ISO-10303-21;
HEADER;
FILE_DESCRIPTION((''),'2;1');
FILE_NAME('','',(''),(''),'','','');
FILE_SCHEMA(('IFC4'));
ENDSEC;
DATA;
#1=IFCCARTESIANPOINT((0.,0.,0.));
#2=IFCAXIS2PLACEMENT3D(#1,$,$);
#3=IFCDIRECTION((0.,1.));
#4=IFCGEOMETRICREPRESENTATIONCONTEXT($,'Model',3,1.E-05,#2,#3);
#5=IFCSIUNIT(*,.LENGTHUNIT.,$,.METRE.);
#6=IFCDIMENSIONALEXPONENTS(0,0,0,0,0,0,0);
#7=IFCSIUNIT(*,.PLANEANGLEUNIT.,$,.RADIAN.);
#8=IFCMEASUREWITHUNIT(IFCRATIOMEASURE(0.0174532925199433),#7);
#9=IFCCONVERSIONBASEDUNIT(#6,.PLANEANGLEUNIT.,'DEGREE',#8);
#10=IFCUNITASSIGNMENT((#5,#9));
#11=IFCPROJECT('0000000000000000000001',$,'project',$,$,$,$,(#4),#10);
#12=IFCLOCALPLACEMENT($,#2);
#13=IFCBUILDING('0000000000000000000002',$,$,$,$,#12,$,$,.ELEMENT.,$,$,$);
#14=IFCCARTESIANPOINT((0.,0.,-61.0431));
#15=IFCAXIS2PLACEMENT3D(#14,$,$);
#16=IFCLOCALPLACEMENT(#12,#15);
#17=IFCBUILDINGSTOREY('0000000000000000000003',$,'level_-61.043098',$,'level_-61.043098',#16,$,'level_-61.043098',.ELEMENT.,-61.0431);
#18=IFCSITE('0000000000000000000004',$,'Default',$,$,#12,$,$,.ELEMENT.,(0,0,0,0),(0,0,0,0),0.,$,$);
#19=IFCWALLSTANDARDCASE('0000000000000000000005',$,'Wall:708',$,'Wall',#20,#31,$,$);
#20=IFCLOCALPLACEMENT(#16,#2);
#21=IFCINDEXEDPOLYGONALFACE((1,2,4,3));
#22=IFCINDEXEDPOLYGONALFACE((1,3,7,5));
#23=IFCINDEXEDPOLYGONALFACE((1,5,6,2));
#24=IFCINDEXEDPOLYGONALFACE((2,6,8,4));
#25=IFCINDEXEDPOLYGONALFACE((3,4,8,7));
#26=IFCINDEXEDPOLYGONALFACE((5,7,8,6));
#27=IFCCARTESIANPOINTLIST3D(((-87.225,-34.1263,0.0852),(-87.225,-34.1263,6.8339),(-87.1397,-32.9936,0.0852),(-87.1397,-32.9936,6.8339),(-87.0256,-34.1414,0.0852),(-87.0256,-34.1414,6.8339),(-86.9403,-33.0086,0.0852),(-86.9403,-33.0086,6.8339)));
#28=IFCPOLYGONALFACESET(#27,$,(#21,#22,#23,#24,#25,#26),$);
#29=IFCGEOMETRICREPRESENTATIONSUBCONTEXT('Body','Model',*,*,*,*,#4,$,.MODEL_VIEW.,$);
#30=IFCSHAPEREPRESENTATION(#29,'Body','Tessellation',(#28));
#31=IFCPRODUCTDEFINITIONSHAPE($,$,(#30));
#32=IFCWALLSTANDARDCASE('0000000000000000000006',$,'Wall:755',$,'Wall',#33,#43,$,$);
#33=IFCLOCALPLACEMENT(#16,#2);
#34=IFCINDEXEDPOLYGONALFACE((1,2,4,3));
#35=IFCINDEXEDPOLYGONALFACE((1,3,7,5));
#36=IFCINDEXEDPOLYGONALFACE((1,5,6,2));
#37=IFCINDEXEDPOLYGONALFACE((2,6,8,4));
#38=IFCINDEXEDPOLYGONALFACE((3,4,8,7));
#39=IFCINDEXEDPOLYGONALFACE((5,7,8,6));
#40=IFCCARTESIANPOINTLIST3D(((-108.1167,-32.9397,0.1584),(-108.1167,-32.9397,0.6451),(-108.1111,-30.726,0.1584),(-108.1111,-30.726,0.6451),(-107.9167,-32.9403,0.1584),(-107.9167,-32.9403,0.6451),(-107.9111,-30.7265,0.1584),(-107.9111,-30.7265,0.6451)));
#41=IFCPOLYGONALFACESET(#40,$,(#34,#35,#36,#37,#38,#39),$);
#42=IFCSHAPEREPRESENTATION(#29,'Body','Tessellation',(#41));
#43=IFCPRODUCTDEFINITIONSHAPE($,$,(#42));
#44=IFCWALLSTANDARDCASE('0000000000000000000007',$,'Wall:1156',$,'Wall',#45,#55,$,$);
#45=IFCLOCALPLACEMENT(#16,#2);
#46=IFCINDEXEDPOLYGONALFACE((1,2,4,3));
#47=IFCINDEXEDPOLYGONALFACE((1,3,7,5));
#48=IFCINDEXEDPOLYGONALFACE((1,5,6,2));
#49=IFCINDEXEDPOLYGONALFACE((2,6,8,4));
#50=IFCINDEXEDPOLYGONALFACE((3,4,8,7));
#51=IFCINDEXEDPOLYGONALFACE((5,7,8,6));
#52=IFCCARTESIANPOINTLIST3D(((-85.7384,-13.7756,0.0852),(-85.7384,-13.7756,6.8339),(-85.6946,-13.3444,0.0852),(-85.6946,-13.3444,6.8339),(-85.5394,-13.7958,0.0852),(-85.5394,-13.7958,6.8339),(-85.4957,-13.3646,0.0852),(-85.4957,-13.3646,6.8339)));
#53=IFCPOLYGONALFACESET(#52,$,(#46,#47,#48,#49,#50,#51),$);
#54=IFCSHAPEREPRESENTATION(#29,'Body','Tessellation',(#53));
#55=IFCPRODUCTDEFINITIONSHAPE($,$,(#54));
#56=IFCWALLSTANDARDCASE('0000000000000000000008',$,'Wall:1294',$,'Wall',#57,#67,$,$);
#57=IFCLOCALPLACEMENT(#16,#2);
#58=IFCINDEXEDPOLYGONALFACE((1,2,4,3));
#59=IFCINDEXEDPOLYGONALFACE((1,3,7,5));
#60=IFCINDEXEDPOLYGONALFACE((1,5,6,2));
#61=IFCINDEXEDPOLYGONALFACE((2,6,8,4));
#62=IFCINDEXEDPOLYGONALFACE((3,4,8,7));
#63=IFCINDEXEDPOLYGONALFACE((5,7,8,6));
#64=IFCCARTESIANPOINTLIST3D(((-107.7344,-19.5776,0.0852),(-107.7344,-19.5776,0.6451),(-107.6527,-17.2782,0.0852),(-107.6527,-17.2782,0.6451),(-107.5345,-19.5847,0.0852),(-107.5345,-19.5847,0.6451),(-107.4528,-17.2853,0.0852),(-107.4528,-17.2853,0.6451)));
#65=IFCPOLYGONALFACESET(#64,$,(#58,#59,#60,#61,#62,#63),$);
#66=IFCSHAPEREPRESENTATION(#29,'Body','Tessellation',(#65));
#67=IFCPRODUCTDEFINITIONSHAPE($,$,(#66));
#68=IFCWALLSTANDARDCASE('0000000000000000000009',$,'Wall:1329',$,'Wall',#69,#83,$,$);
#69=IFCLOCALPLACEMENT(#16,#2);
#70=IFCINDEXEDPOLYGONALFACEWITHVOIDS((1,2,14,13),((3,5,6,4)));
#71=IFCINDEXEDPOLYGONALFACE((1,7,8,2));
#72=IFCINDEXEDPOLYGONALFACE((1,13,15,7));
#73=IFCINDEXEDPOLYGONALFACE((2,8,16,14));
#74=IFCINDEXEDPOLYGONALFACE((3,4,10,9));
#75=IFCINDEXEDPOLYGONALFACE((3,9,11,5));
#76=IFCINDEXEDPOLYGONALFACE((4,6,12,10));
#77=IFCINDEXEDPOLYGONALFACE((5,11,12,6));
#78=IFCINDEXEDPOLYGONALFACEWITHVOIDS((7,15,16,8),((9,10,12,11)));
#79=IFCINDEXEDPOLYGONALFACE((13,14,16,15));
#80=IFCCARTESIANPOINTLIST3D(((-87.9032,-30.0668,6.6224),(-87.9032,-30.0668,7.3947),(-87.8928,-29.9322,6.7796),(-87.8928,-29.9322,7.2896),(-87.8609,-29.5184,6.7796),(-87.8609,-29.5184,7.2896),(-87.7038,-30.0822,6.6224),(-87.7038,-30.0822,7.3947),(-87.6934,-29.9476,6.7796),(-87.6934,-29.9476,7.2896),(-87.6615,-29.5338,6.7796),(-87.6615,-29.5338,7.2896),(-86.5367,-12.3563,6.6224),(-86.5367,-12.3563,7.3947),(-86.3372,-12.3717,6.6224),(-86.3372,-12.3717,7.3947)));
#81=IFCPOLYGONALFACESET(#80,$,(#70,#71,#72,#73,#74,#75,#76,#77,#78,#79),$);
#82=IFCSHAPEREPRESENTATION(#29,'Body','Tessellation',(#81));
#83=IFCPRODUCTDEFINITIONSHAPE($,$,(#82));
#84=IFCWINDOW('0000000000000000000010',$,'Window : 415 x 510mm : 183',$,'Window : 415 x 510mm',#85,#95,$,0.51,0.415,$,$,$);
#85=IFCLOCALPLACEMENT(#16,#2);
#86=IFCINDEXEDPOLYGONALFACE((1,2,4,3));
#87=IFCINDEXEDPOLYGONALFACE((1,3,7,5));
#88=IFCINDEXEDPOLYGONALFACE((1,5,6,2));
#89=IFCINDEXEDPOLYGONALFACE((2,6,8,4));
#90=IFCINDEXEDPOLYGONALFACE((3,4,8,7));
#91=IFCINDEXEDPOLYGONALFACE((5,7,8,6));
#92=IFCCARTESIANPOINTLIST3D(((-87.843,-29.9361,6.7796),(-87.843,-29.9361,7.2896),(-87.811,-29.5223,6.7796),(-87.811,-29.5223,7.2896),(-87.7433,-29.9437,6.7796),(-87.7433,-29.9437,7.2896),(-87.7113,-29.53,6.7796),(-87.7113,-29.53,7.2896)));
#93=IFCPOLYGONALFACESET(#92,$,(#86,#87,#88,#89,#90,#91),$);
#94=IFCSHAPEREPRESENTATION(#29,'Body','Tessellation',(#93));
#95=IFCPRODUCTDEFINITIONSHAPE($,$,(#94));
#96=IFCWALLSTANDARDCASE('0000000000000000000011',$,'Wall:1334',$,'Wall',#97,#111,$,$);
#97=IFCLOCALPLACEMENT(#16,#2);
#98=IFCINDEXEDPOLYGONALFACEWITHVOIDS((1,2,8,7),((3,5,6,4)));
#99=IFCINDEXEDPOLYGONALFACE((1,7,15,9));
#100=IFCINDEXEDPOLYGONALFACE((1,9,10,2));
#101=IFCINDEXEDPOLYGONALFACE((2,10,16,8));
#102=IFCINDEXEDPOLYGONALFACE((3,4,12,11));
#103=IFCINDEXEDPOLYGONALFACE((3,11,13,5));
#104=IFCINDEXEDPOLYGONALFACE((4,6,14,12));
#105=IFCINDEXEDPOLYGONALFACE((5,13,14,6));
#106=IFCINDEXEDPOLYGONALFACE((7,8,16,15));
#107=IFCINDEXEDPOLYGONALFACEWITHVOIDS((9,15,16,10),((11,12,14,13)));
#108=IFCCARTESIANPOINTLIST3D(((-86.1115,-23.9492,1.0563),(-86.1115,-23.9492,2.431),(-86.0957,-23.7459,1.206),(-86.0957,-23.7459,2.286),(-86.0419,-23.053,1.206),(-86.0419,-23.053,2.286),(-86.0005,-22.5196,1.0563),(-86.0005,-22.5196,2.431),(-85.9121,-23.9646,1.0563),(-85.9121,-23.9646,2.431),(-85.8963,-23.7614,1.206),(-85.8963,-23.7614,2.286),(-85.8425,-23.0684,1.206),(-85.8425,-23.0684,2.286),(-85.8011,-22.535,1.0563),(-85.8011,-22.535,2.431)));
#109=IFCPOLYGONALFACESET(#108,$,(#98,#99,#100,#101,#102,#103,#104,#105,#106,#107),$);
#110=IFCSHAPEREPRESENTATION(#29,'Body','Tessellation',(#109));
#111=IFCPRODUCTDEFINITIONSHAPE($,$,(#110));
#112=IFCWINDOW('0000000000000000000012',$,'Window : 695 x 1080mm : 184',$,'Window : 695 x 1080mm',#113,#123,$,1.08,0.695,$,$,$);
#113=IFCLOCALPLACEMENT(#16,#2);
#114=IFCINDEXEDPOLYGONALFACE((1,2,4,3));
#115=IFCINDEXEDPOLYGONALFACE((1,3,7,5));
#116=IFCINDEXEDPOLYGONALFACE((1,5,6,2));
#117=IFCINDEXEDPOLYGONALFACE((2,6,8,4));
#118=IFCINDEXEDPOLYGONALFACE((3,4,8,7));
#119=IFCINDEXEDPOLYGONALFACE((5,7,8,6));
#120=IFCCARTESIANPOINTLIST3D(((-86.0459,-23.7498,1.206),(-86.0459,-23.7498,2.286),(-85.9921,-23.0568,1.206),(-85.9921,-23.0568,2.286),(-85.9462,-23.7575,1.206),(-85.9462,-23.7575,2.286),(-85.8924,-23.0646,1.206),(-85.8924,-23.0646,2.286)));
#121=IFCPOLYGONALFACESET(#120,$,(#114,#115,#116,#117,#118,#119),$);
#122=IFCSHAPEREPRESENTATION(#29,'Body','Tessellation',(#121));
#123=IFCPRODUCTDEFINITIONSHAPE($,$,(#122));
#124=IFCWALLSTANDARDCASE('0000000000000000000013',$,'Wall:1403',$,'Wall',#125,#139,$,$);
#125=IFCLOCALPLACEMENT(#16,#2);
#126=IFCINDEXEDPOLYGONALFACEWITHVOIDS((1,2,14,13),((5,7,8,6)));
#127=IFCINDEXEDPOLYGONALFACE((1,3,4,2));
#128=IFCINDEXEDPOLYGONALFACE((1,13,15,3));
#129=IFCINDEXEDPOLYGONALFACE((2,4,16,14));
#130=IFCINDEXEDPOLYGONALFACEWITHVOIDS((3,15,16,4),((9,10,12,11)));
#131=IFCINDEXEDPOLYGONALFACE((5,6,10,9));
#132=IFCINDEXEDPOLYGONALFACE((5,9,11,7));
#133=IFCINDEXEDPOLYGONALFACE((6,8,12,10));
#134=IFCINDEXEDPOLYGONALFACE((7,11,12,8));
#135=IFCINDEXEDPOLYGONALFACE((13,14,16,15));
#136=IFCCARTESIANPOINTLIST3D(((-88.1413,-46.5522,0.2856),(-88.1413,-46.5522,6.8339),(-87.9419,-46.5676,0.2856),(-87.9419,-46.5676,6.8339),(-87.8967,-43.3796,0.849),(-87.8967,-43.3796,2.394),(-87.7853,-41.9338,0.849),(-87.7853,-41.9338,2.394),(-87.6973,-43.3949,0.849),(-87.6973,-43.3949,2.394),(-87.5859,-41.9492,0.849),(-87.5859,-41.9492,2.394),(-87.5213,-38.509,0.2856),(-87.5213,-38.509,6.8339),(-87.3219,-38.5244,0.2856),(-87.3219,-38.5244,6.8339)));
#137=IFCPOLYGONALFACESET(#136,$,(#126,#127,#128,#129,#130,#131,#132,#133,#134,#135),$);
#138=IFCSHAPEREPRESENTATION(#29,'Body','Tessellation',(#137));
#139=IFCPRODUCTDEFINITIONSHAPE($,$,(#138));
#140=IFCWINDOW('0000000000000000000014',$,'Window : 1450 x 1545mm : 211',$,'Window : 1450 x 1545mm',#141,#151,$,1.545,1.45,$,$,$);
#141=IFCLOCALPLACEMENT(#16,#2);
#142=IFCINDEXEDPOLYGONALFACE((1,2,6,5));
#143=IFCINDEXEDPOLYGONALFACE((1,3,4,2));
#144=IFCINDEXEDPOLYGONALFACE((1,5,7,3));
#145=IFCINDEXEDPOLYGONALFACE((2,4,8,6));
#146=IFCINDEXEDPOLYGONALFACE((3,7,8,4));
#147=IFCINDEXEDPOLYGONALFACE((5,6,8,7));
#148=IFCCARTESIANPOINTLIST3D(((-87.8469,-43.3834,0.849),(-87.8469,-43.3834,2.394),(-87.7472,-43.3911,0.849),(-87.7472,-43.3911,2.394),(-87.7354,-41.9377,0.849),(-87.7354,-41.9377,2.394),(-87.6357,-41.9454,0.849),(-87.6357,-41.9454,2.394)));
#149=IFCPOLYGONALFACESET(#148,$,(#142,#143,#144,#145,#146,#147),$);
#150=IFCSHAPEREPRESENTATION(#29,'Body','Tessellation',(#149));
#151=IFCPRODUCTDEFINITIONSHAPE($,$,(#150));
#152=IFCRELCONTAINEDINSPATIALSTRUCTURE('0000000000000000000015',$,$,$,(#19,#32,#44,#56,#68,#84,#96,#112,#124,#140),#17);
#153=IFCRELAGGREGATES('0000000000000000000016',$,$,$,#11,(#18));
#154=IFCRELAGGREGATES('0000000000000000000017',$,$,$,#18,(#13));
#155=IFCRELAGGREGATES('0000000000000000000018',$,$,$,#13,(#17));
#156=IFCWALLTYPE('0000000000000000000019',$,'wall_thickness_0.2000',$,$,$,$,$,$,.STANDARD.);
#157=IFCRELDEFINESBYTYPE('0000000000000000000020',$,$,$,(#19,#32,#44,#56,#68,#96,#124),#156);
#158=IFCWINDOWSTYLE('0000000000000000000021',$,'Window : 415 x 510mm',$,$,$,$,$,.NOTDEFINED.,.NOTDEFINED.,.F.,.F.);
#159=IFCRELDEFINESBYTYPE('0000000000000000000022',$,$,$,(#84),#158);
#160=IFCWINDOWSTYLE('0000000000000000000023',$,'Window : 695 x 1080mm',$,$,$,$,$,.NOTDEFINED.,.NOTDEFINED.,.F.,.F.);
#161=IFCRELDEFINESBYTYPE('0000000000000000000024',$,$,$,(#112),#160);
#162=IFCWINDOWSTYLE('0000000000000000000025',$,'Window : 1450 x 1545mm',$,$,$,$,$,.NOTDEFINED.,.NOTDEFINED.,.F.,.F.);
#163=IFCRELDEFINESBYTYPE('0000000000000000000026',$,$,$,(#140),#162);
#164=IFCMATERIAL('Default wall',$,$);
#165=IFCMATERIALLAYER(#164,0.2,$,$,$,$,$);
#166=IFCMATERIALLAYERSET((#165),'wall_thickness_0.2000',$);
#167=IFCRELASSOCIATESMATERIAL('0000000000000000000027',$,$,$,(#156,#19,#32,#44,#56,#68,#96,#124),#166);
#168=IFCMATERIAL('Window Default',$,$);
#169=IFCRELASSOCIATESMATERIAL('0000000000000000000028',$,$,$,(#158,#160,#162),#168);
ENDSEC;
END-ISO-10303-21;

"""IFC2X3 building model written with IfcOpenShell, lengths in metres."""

from ifc_helpers import new_model, entity, si_unit, converted_unit, direction, frame, frame_2d, origin, origin_2d_with_axis, place, context, subcontext, project, spatial, polyline, rectangle, outline, extrude, source, transform, mapped, material, layer, layer_set, layer_usage, type_object, type_shapes, element, fill, save


model = new_model("IFC2X3")

# Units and contexts
model_context = context("Model", 3, precision=1e-05, world=origin(), true_north=direction((0.0, 1.0)))
body_context = subcontext(model_context, "Body", "Model", "MODEL_VIEW")
ifc_project = project(units=[si_unit("LENGTHUNIT", "METRE"), converted_unit("PLANEANGLEUNIT", "DEGREE", entity("IfcRatioMeasure", 0.0174532925199433), si_unit("PLANEANGLEUNIT", "RADIAN"), dimensions=[0, 0, 0, 0, 0, 0, 0])], contexts=[model_context])

# Site, building, storey
placement_1 = place(None, origin())
site = spatial("IfcSite", under=ifc_project, at=placement_1, Name="Default", CompositionType="ELEMENT", RefLatitude=(0, 0, 0, 0), RefLongitude=(0, 0, 0, 0), RefElevation=0.0)
building = spatial("IfcBuilding", under=site, at=placement_1, CompositionType="ELEMENT")
storey_placement = place(placement_1, frame((0.0, 0.0, -61.0431)))
storey = spatial("IfcBuildingStorey", under=building, at=storey_placement, Name="level_-61.043098", ObjectType="level_-61.043098", LongName="level_-61.043098", CompositionType="ELEMENT", Elevation=-61.0431)

# Shared definitions
ifc_material_1 = material(Name="Default wall")
ifc_layer = layer(ifc_material_1, 0.2)
ifc_layer_set = layer_set([ifc_layer], Name="wall_thickness_0.2000")
ifc_layer_usage = layer_usage(ifc_layer_set, "AXIS2", "POSITIVE", -0.1)
wall_type = type_object("IfcWallType", Name="wall_thickness_0.2000", PredefinedType="STANDARD", material=ifc_layer_set)

# Shared definitions
ifc_material_2 = material(Name="Window Default")

# Walls
placement_2 = place(placement_1, frame((0.0, 0.0, -60.9579)))
wall_1_placement = place(placement_2, frame((-87.1253, -34.1339, 0.0), z_axis=(0.0, 0.0, 1.0), x_axis=(0.075094, 0.997176, 0.0)))
element("IfcWallStandardCase", 1, at=wall_1_placement, inside=storey, type_object=wall_type, material=ifc_layer_usage, Name="Wall:708", ObjectType="Wall", context=body_context, shape_type="SweptSolid", body=[
    extrude(outline(polyline([(1.136, -0.1), (1.136, 0.1), (0.0, 0.1), (0.0, -0.1), (1.136, -0.1)])), origin(), (0.0, 0.0, 1.0), 6.7487),
])
placement_3 = place(placement_1, frame((0.0, 0.0, -60.8847)))
wall_2_placement = place(placement_3, frame((-108.0167, -32.94, 0.0), z_axis=(0.0, 0.0, 1.0), x_axis=(0.002509, 0.999997, 0.0)))
element("IfcWallStandardCase", 2, at=wall_2_placement, inside=storey, type_object=wall_type, material=ifc_layer_usage, Name="Wall:755", ObjectType="Wall", context=body_context, shape_type="SweptSolid", body=[
    extrude(outline(polyline([(2.2138, -0.1), (2.2138, 0.1), (0.0, 0.1), (0.0, -0.1), (2.2138, -0.1)])), origin(), (0.0, 0.0, 1.0), 0.4867),
])
placement_4 = place(placement_1, frame((0.0, 0.0, -60.9579)))
wall_3_placement = place(placement_4, frame((-85.6389, -13.7857, 0.0), z_axis=(0.0, 0.0, 1.0), x_axis=(0.100936, 0.994893, 0.0)))
element("IfcWallStandardCase", 3, at=wall_3_placement, inside=storey, type_object=wall_type, material=ifc_layer_usage, Name="Wall:1156", ObjectType="Wall", context=body_context, shape_type="SweptSolid", body=[
    extrude(outline(polyline([(0.4334, -0.1), (0.4334, 0.1), (0.0, 0.1), (0.0, -0.1), (0.4334, -0.1)])), origin(), (0.0, 0.0, 1.0), 6.7487),
])
placement_5 = place(placement_1, frame((0.0, 0.0, -60.9579)))
wall_4_placement = place(placement_5, frame((-107.6345, -19.5812, 0.0), z_axis=(0.0, 0.0, 1.0), x_axis=(0.035503, 0.99937, 0.0)))
element("IfcWallStandardCase", 4, at=wall_4_placement, inside=storey, type_object=wall_type, material=ifc_layer_usage, Name="Wall:1294", ObjectType="Wall", context=body_context, shape_type="SweptSolid", body=[
    extrude(outline(polyline([(2.3009, -0.1), (2.3009, 0.1), (0.0, 0.1), (0.0, -0.1), (2.3009, -0.1)])), origin(), (0.0, 0.0, 1.0), 0.5598),
])

# Walls, openings, windows
placement_6 = place(placement_1, frame((0.0, 0.0, -54.4207)))
wall_5_placement = place(placement_6, frame((-87.8035, -30.0745, 0.0), z_axis=(0.0, 0.0, 1.0), x_axis=(0.076932, 0.997036, 0.0)))
wall_5 = element("IfcWallStandardCase", 5, at=wall_5_placement, inside=storey, type_object=wall_type, material=ifc_layer_usage, Name="Wall:1329", ObjectType="Wall", context=body_context, shape_type="SweptSolid", body=[
    extrude(outline(polyline([(17.7631, -0.1), (17.7631, 0.1), (0.0, 0.1), (0.0, -0.1), (17.7631, -0.1)])), origin(), (0.0, 0.0, 1.0), 0.7723),
])
opening_1_placement = place(wall_5_placement, frame((0.135, -0.1, 0.1572)))
opening_1 = element("IfcOpeningElement", 6, at=opening_1_placement, cuts=wall_5, ObjectType="Opening", context=body_context, shape_type="SweptSolid", body=[
    extrude(rectangle(XDim=0.415, YDim=0.51, at=frame_2d((0.255, 0.2075), x_axis=(0.0, 1.0))), frame((0.0, 0.0, 0.0), z_axis=(0.0, 1.0, 0.0), x_axis=(0.0, 0.0, 1.0)), (0.0, 0.0, 1.0), 0.2),
])
window_style_1 = type_object("IfcWindowStyle", Name="Window : 415 x 510mm", ConstructionType="NOTDEFINED", OperationType="NOTDEFINED", ParameterTakesPrecedence=False, Sizeable=False, material=ifc_material_2)
shared_shape_1 = source(origin(), body_context, "Body", "SweptSolid", [
    extrude(rectangle(XDim=0.1, YDim=0.415, at=origin_2d_with_axis()), frame((0.2075, 0.1, 0.0), z_axis=(0.0, 0.0, 1.0), x_axis=(0.0, 1.0, 0.0)), (0.0, 0.0, 1.0), 0.51),
])
type_shapes(window_style_1, [shared_shape_1])
window_1_placement = place(opening_1_placement, origin())
window_1 = element("IfcWindow", 7, at=window_1_placement, inside=storey, type_object=window_style_1, Name="Window : 415 x 510mm : 183", ObjectType="Window : 415 x 510mm", OverallHeight=0.51, OverallWidth=0.415, context=body_context, shape_type="MappedRepresentation", body=[
    mapped(shared_shape_1, transform((0.0, 0.0, 0.0), scale=1.0)),
])
fill(opening_1, window_1)
placement_7 = place(placement_1, frame((0.0, 0.0, -59.9868)))
wall_6_placement = place(placement_7, frame((-85.9008, -22.5273, 0.0), z_axis=(0.0, 0.0, 1.0), x_axis=(-0.077369, -0.997003, 0.0)))
wall_6 = element("IfcWallStandardCase", 8, at=wall_6_placement, inside=storey, type_object=wall_type, material=ifc_layer_usage, Name="Wall:1334", ObjectType="Wall", context=body_context, shape_type="SweptSolid", body=[
    extrude(outline(polyline([(1.4339, -0.1), (1.4339, 0.1), (0.0, 0.1), (0.0, -0.1), (1.4339, -0.1)])), origin(), (0.0, 0.0, 1.0), 1.3747),
])
opening_2_placement = place(wall_6_placement, frame((0.535, -0.1, 0.1497)))
opening_2 = element("IfcOpeningElement", 9, at=opening_2_placement, cuts=wall_6, ObjectType="Opening", context=body_context, shape_type="SweptSolid", body=[
    extrude(rectangle(XDim=0.695, YDim=1.08, at=frame_2d((0.54, 0.3475), x_axis=(0.0, 1.0))), frame((0.0, 0.0, 0.0), z_axis=(0.0, 1.0, 0.0), x_axis=(0.0, 0.0, 1.0)), (0.0, 0.0, 1.0), 0.2),
])
window_style_2 = type_object("IfcWindowStyle", Name="Window : 695 x 1080mm", ConstructionType="NOTDEFINED", OperationType="NOTDEFINED", ParameterTakesPrecedence=False, Sizeable=False, material=ifc_material_2)
shared_shape_2 = source(origin(), body_context, "Body", "SweptSolid", [
    extrude(rectangle(XDim=0.1, YDim=0.695, at=origin_2d_with_axis()), frame((0.3475, 0.1, 0.0), z_axis=(0.0, 0.0, 1.0), x_axis=(0.0, 1.0, 0.0)), (0.0, 0.0, 1.0), 1.08),
])
type_shapes(window_style_2, [shared_shape_2])
window_2_placement = place(opening_2_placement, origin())
window_2 = element("IfcWindow", 10, at=window_2_placement, inside=storey, type_object=window_style_2, Name="Window : 695 x 1080mm : 184", ObjectType="Window : 695 x 1080mm", OverallHeight=1.08, OverallWidth=0.695, context=body_context, shape_type="MappedRepresentation", body=[
    mapped(shared_shape_2, transform((0.0, 0.0, 0.0), scale=1.0)),
])
fill(opening_2, window_2)
placement_8 = place(placement_1, frame((0.0, 0.0, -60.7575)))
wall_7_placement = place(placement_8, frame((-87.4216, -38.5167, 0.0), z_axis=(0.0, 0.0, 1.0), x_axis=(-0.076849, -0.997043, 0.0)))
wall_7 = element("IfcWallStandardCase", 11, at=wall_7_placement, inside=storey, type_object=wall_type, material=ifc_layer_usage, Name="Wall:1403", ObjectType="Wall", context=body_context, shape_type="SweptSolid", body=[
    extrude(outline(polyline([(8.067, -0.1), (8.067, 0.1), (0.0, 0.1), (0.0, -0.1), (8.067, -0.1)])), origin(), (0.0, 0.0, 1.0), 6.5483),
])
opening_3_placement = place(wall_7_placement, frame((3.435, -0.1, 0.5635)))
opening_3 = element("IfcOpeningElement", 12, at=opening_3_placement, cuts=wall_7, ObjectType="Opening", context=body_context, shape_type="SweptSolid", body=[
    extrude(rectangle(XDim=1.45, YDim=1.545, at=frame_2d((0.7725, 0.725), x_axis=(0.0, 1.0))), frame((0.0, 0.0, 0.0), z_axis=(0.0, 1.0, 0.0), x_axis=(0.0, 0.0, 1.0)), (0.0, 0.0, 1.0), 0.2),
])
window_style_3 = type_object("IfcWindowStyle", Name="Window : 1450 x 1545mm", ConstructionType="NOTDEFINED", OperationType="NOTDEFINED", ParameterTakesPrecedence=False, Sizeable=False, material=ifc_material_2)
shared_shape_3 = source(origin(), body_context, "Body", "SweptSolid", [
    extrude(rectangle(XDim=0.1, YDim=1.45, at=origin_2d_with_axis()), frame((0.725, 0.1, 0.0), z_axis=(0.0, 0.0, 1.0), x_axis=(0.0, 1.0, 0.0)), (0.0, 0.0, 1.0), 1.545),
])
type_shapes(window_style_3, [shared_shape_3])
window_3_placement = place(opening_3_placement, origin())
window_3 = element("IfcWindow", 13, at=window_3_placement, inside=storey, type_object=window_style_3, Name="Window : 1450 x 1545mm : 211", ObjectType="Window : 1450 x 1545mm", OverallHeight=1.545, OverallWidth=1.45, context=body_context, shape_type="MappedRepresentation", body=[
    mapped(shared_shape_3, transform((0.0, 0.0, 0.0), scale=1.0)),
])
fill(opening_3, window_3)

save(model, "model.ifc")
